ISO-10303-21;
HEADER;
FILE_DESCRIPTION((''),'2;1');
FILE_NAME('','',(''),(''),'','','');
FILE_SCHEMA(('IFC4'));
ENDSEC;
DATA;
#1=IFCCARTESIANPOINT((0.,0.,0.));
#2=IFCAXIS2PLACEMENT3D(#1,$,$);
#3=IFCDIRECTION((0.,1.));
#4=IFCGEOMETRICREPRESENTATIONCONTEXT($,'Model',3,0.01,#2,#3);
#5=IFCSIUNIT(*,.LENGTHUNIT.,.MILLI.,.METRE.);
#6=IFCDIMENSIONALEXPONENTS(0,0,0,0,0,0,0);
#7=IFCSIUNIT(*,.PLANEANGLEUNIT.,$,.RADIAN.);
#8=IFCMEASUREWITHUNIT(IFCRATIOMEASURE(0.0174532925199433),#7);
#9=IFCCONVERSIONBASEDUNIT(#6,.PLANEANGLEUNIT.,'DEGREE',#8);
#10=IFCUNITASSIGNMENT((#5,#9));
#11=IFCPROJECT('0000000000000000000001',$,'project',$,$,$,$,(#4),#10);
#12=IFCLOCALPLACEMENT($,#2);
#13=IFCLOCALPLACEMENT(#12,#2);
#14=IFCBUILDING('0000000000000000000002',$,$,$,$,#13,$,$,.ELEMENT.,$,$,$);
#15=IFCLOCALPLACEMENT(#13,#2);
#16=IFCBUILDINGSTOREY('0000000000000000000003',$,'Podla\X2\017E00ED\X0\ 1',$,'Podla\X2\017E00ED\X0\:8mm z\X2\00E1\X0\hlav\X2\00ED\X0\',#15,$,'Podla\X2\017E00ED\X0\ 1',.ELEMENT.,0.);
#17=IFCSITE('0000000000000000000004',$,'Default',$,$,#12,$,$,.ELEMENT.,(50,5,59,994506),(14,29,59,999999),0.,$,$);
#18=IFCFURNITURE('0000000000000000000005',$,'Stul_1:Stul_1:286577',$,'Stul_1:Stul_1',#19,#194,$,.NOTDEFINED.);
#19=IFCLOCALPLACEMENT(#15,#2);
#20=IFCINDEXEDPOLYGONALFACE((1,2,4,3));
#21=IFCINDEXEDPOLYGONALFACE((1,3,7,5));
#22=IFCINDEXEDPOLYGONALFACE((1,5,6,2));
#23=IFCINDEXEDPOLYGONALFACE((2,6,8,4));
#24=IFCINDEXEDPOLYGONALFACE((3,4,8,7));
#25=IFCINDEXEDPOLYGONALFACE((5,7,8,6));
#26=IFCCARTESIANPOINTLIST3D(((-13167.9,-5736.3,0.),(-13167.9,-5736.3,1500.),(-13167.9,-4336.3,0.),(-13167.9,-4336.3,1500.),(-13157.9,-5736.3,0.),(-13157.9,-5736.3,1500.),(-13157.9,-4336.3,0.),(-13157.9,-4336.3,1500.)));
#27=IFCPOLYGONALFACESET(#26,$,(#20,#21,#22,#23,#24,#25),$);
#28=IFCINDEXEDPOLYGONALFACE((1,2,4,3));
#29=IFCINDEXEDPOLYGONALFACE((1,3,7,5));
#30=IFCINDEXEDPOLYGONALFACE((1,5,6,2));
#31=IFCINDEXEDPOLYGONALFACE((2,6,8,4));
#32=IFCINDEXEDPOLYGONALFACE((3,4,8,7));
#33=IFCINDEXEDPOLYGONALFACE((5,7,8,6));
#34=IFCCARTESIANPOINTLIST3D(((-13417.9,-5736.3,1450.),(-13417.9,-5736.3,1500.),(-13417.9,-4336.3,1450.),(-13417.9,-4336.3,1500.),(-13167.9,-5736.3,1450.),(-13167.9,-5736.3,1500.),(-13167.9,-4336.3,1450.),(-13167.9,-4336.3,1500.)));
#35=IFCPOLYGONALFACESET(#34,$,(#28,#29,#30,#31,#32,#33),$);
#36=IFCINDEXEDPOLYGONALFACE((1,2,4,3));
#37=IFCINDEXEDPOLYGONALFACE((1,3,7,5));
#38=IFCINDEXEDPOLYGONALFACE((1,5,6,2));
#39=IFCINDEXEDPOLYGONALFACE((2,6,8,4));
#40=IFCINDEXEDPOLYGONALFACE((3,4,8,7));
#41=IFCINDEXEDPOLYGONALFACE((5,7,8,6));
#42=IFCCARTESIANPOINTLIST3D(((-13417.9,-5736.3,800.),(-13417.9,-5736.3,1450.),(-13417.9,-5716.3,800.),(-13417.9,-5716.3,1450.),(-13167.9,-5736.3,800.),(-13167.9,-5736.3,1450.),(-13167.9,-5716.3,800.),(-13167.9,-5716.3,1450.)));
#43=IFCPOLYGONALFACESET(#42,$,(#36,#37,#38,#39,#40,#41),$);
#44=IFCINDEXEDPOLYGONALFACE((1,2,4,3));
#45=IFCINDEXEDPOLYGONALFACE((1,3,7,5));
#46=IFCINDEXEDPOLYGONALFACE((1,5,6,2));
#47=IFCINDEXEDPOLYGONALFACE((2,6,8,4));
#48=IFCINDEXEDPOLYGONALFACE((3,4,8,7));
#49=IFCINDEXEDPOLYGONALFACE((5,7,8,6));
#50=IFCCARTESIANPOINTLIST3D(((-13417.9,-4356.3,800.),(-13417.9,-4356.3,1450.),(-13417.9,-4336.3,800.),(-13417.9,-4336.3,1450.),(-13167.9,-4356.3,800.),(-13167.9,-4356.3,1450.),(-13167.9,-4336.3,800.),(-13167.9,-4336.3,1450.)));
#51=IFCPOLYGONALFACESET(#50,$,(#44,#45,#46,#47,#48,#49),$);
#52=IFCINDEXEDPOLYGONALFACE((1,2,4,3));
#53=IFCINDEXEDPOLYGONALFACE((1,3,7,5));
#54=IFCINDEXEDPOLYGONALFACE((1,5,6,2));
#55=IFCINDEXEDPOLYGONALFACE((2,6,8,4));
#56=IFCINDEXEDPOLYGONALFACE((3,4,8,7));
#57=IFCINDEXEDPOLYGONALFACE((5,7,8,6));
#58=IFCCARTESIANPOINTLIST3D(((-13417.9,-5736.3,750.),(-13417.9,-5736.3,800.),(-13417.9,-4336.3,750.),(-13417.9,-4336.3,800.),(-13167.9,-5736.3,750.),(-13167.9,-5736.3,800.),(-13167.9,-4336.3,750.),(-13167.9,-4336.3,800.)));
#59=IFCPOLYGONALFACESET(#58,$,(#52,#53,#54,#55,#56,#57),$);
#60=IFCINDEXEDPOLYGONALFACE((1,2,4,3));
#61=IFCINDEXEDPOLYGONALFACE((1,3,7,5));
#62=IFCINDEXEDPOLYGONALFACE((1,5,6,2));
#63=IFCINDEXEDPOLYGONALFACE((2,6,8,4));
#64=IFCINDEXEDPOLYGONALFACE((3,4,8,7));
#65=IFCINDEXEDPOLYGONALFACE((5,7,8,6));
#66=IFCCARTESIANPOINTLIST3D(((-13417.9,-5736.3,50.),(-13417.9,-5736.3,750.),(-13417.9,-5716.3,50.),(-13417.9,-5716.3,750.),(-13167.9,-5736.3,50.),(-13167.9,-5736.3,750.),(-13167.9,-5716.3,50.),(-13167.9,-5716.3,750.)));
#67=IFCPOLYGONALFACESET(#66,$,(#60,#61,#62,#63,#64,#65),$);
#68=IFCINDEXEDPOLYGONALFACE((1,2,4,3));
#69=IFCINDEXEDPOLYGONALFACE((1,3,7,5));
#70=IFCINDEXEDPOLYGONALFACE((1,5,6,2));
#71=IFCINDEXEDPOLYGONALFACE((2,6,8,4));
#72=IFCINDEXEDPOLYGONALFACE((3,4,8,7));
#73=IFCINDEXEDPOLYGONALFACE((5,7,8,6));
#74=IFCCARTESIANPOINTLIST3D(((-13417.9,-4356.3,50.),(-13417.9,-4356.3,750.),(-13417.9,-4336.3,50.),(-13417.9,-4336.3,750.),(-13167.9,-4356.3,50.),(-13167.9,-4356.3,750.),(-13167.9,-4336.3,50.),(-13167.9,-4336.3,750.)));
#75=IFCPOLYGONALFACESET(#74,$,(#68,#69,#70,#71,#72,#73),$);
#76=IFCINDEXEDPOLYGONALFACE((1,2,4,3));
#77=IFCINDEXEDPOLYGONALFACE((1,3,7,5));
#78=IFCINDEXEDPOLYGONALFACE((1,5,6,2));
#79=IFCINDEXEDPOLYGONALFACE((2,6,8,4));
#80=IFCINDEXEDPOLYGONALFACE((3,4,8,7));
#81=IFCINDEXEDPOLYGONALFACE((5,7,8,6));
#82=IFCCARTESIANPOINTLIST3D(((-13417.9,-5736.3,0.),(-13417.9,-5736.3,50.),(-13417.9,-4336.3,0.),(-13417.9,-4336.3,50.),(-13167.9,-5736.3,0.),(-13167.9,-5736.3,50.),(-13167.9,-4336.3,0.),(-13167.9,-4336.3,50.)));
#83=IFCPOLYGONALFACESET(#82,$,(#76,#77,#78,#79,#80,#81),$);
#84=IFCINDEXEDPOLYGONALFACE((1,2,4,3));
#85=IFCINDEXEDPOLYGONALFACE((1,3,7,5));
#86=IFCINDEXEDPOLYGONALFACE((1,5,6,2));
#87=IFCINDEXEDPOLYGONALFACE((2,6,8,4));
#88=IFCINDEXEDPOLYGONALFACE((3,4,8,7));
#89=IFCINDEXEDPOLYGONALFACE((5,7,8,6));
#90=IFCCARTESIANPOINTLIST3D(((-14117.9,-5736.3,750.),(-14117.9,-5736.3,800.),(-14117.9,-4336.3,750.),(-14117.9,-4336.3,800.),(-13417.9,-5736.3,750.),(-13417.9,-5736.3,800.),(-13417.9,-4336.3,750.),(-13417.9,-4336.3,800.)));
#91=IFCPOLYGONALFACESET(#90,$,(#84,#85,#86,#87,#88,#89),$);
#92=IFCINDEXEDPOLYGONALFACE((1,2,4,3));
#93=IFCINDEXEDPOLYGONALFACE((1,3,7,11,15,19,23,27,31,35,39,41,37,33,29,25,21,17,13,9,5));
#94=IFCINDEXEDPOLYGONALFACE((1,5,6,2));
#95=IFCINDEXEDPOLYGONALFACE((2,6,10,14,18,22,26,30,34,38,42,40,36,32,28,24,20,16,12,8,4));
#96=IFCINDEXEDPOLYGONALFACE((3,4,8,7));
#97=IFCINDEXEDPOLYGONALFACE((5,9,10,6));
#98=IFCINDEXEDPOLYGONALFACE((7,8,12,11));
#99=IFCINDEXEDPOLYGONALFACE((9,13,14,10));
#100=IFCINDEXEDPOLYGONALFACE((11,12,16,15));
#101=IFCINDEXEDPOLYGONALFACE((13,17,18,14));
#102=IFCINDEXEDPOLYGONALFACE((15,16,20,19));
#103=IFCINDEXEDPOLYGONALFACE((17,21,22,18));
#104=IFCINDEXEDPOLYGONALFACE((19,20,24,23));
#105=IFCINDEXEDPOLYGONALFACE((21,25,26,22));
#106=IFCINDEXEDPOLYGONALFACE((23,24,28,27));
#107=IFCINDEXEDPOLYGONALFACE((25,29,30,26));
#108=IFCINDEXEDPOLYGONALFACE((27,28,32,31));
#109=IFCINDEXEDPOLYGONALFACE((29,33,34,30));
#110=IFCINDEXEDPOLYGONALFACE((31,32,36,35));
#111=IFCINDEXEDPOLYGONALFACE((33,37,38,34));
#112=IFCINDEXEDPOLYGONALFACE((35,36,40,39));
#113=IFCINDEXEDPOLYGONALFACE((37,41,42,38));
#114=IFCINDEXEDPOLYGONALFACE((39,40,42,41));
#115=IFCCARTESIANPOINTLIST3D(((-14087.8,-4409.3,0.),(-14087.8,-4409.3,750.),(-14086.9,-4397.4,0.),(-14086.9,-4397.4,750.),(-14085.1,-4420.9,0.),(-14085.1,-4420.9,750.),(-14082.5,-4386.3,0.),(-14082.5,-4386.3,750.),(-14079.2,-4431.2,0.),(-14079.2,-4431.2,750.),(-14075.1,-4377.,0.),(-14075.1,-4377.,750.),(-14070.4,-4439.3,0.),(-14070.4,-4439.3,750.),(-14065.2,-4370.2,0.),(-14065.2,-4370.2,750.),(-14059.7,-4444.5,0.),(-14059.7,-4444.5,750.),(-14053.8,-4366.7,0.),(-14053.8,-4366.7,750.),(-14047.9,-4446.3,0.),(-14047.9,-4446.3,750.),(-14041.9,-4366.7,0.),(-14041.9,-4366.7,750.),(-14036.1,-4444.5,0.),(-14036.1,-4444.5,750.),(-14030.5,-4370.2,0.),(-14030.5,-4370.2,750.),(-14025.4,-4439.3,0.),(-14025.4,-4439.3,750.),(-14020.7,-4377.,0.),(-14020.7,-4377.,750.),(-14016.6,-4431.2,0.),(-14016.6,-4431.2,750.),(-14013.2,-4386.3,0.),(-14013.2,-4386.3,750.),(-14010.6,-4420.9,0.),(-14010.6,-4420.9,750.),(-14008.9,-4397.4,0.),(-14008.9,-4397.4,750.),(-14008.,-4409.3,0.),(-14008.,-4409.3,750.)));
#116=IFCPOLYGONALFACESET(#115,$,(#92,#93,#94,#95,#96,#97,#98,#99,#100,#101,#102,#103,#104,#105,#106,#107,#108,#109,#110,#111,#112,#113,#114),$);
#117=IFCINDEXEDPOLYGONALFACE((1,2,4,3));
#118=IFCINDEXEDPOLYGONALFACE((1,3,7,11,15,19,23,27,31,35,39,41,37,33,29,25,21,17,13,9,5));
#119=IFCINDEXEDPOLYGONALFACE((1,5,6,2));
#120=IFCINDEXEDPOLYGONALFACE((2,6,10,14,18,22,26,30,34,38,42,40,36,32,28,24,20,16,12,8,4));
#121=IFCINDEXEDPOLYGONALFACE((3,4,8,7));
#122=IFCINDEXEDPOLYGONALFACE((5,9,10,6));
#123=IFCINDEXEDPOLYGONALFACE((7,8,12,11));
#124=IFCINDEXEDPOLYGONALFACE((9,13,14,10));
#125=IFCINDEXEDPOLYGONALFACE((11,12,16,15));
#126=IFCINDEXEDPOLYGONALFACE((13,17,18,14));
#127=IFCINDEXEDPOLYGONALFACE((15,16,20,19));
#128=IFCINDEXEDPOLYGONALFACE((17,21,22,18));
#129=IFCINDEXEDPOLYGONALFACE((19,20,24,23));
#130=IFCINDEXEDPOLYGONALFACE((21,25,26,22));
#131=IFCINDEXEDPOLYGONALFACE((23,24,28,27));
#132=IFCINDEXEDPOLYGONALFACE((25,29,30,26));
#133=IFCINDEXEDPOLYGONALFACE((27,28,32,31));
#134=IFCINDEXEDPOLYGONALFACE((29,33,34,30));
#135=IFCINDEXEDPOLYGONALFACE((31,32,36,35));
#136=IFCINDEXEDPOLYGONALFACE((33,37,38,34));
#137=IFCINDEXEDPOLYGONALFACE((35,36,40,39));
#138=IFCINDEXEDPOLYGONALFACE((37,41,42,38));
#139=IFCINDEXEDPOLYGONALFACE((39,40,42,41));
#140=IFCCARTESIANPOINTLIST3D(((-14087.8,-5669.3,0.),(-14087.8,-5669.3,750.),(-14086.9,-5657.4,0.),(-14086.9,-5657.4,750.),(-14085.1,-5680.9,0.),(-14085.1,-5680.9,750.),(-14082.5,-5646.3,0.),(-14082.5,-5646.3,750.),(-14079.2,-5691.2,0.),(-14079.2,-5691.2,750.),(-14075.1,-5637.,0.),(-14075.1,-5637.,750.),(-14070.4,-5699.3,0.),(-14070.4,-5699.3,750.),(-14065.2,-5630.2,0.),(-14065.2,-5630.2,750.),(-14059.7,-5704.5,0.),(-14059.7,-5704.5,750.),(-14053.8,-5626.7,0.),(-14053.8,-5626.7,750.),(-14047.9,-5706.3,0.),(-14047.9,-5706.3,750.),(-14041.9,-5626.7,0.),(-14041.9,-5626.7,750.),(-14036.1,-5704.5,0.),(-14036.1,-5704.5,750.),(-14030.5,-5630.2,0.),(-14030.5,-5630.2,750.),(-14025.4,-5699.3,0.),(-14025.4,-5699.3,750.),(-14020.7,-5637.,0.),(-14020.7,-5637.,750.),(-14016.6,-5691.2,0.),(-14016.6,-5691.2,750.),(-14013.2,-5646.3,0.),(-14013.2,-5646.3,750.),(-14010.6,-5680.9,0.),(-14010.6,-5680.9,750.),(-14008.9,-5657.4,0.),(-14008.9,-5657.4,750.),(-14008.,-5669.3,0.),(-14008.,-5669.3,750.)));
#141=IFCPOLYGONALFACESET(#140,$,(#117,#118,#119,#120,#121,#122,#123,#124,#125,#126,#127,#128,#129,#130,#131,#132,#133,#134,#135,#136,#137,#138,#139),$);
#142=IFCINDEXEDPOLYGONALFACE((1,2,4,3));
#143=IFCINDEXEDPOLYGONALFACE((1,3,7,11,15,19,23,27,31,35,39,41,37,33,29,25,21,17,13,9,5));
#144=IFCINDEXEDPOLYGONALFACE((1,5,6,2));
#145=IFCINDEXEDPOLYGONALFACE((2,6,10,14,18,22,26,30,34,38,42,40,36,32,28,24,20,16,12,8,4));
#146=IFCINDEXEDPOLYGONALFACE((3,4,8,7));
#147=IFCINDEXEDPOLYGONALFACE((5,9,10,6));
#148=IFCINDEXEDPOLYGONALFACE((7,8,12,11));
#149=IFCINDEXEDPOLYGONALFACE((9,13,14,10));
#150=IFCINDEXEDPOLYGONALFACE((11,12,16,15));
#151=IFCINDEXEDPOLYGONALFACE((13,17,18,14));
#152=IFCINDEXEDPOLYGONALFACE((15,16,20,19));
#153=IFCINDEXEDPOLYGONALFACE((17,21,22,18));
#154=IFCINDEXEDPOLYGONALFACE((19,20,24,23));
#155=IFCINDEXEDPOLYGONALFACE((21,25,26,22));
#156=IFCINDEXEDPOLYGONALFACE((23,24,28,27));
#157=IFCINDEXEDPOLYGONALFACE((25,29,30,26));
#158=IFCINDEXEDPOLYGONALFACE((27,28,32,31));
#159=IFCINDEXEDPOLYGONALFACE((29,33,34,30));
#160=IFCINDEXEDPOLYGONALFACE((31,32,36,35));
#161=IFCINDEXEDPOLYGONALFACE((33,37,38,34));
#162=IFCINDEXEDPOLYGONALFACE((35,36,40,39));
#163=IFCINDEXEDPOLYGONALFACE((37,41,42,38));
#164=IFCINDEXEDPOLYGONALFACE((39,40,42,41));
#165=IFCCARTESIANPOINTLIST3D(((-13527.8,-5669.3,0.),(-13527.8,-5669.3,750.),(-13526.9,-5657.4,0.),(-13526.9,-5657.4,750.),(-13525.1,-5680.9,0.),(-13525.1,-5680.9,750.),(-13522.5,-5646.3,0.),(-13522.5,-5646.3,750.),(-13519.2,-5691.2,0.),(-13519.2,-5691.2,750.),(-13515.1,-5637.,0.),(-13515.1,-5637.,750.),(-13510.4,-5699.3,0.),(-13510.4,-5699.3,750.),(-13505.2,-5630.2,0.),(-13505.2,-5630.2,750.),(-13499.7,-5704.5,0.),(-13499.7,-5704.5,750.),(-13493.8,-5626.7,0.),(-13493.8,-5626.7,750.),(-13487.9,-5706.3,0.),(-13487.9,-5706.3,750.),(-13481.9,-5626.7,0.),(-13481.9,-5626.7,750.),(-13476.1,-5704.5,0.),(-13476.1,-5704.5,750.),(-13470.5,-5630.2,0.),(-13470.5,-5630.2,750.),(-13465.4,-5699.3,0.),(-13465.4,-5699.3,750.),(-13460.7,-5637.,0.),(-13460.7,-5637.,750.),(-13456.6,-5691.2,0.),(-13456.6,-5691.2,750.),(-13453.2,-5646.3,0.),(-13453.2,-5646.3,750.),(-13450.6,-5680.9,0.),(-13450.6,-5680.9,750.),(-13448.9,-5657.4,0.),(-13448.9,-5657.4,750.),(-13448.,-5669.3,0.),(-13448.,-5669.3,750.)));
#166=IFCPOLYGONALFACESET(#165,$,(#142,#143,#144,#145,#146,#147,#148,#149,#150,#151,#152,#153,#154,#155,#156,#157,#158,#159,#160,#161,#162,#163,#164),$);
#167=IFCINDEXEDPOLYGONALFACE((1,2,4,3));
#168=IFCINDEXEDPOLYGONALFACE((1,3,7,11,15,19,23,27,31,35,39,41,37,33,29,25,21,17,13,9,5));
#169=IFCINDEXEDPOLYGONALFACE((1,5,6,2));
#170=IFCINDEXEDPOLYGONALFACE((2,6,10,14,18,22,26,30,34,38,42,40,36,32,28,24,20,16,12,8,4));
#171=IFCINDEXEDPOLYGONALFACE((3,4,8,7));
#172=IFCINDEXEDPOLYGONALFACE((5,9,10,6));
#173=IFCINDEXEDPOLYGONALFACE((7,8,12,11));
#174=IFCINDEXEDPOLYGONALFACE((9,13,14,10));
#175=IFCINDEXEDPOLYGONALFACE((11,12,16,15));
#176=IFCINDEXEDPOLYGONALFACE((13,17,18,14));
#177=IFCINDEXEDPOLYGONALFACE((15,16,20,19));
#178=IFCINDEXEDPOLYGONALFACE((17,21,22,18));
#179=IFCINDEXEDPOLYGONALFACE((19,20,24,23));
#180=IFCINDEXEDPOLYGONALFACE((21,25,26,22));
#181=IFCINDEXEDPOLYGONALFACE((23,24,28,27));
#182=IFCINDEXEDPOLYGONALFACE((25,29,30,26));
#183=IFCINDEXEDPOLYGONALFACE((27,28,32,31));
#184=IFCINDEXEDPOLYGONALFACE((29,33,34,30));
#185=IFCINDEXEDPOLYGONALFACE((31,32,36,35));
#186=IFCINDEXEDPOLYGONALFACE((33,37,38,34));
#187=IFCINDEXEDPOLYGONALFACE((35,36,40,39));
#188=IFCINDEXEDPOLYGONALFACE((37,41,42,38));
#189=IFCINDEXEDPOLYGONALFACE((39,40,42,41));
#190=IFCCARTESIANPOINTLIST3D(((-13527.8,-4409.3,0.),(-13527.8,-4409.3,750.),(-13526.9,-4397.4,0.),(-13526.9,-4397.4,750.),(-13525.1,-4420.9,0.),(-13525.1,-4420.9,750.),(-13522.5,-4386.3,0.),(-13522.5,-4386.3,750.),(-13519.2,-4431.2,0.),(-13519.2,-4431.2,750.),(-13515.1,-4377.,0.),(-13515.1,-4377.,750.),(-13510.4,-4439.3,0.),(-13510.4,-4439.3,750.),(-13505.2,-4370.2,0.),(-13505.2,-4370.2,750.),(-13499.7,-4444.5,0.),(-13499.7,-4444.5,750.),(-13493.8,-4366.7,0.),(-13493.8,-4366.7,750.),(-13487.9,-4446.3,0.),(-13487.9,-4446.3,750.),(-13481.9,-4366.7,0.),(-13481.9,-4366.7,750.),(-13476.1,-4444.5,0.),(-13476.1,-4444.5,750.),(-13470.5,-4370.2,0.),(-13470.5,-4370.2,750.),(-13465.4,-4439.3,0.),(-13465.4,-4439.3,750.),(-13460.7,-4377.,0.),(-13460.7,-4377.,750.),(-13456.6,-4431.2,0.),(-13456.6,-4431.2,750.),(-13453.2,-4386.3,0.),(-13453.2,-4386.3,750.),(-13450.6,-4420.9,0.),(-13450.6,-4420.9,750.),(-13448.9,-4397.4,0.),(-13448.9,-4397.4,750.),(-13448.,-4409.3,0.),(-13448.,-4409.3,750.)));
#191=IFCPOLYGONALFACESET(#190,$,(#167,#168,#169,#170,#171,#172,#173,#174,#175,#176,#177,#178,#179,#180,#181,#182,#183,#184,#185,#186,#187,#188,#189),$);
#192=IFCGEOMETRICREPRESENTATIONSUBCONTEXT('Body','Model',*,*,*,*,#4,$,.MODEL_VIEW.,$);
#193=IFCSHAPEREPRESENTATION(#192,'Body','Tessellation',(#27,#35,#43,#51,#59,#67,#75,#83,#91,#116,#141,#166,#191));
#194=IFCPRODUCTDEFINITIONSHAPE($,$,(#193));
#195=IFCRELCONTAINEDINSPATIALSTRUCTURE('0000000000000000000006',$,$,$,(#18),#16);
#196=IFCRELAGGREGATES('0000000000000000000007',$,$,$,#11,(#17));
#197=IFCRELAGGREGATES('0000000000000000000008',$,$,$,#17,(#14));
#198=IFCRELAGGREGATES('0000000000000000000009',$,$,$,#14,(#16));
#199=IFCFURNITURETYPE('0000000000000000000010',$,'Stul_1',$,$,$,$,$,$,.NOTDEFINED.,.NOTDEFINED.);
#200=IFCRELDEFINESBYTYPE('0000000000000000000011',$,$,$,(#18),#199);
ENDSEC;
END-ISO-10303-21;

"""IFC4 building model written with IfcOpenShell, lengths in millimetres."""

from ifc_helpers import new_model, entity, si_unit, converted_unit, direction, frame, frame_2d, origin, origin_2d_with_axis, place, context, subcontext, project, spatial, rectangle, circle, extrude, source, transform, mapped, type_object, type_shapes, element, save


model = new_model("IFC4")

# Units and contexts
model_context = context("Model", 3, precision=0.01, world=origin(), true_north=direction((0.0, 1.0)))
body_context = subcontext(model_context, "Body", "Model", "MODEL_VIEW")
ifc_project = project(units=[si_unit("LENGTHUNIT", "METRE", prefix="MILLI"), converted_unit("PLANEANGLEUNIT", "DEGREE", entity("IfcRatioMeasure", 0.0174532925199433), si_unit("PLANEANGLEUNIT", "RADIAN"), dimensions=[0, 0, 0, 0, 0, 0, 0])], contexts=[model_context])

# Site, building, storey
site_placement = place(None, origin())
site = spatial("IfcSite", under=ifc_project, at=site_placement, Name="Default", CompositionType="ELEMENT", RefLatitude=(50, 5, 59, 994506), RefLongitude=(14, 29, 59, 999999), RefElevation=0.0)
building_placement = place(site_placement, origin())
building = spatial("IfcBuilding", under=site, at=building_placement, CompositionType="ELEMENT")
storey_placement = place(building_placement, origin())
storey = spatial("IfcBuildingStorey", under=building, at=storey_placement, Name="Podlaží 1", ObjectType="Podlaží:8mm záhlaví", LongName="Podlaží 1", CompositionType="ELEMENT", Elevation=0.0)

# Furniture
furniture_type = type_object("IfcFurnitureType", Name="Stul_1", AssemblyPlace="NOTDEFINED", PredefinedType="NOTDEFINED")
shared_shape_1 = source(origin(), body_context, "Body", "SweptSolid", [
    extrude(rectangle(XDim=1400.0, YDim=10.0, at=origin_2d_with_axis()), frame((0.0, 605.0, 0.0), z_axis=(0.0, 0.0, 1.0), x_axis=(-1.0, 0.0, 0.0)), (0.0, 0.0, 1.0), 1500.0),
    extrude(rectangle(XDim=1400.0, YDim=250.0, at=frame_2d((0.0, 0.0), x_axis=(1.0, 0.0))), frame((0.0, 475.0, 1450.0), z_axis=(0.0, 0.0, 1.0), x_axis=(-1.0, 0.0, 0.0)), (0.0, 0.0, 1.0), 50.0),
    extrude(rectangle(XDim=20.0, YDim=250.0, at=origin_2d_with_axis()), frame((690.0, 475.0, 800.0), z_axis=(0.0, 0.0, 1.0), x_axis=(-1.0, 0.0, 0.0)), (0.0, 0.0, 1.0), 650.0),
    extrude(rectangle(XDim=20.0, YDim=250.0, at=frame_2d((0.0, 0.0), x_axis=(1.0, 0.0))), frame((-690.0, 475.0, 800.0), z_axis=(0.0, 0.0, 1.0), x_axis=(-1.0, 0.0, 0.0)), (0.0, 0.0, 1.0), 650.0),
    extrude(rectangle(XDim=1400.0, YDim=250.0, at=origin_2d_with_axis()), frame((0.0, 475.0, 750.0), z_axis=(0.0, 0.0, 1.0), x_axis=(-1.0, 0.0, 0.0)), (0.0, 0.0, 1.0), 50.0),
    extrude(rectangle(XDim=20.0, YDim=250.0, at=origin_2d_with_axis()), frame((690.0, 475.0, 50.0), z_axis=(0.0, 0.0, 1.0), x_axis=(-1.0, 0.0, 0.0)), (0.0, 0.0, 1.0), 700.0),
    extrude(rectangle(XDim=20.0, YDim=250.0, at=frame_2d((0.0, 0.0), x_axis=(1.0, 0.0))), frame((-690.0, 475.0, 50.0), z_axis=(0.0, 0.0, 1.0), x_axis=(-1.0, 0.0, 0.0)), (0.0, 0.0, 1.0), 700.0),
    extrude(rectangle(XDim=1400.0, YDim=250.0, at=origin_2d_with_axis()), frame((0.0, 475.0, 0.0), z_axis=(0.0, 0.0, 1.0), x_axis=(-1.0, 0.0, 0.0)), (0.0, 0.0, 1.0), 50.0),
    extrude(rectangle(XDim=1400.0, YDim=700.0, at=origin_2d_with_axis()), frame((0.0, 0.0, 750.0), z_axis=(0.0, 0.0, 1.0), x_axis=(-1.0, 0.0, 0.0)), (0.0, 0.0, 1.0), 50.0),
    extrude(circle(Radius=40.0, at=frame_2d((0.0, 0.0), x_axis=(1.0, 0.0))), frame((-630.0, -280.0, 0.0)), (0.0, 0.0, 1.0), 750.0),
    extrude(circle(Radius=40.0, at=frame_2d((0.0, 0.0), x_axis=(1.0, 0.0))), frame((630.0, -280.0, 0.0)), (0.0, 0.0, 1.0), 750.0),
    extrude(circle(Radius=40.0, at=frame_2d((0.0, 0.0), x_axis=(1.0, 0.0))), frame((630.0, 280.0, 0.0)), (0.0, 0.0, 1.0), 750.0),
    extrude(circle(Radius=40.0, at=frame_2d((0.0, 0.0), x_axis=(1.0, 0.0))), frame((-630.0, 280.0, 0.0)), (0.0, 0.0, 1.0), 750.0),
])
type_shapes(furniture_type, [shared_shape_1])
for number, where, z_axis, x_axis, name in (
    (1, (-13767.9, -5036.3, 0.0), (0.0, 0.0, 1.0), (0.0, -1.0, 0.0), "Stul_1:Stul_1:286577"),
):
    element("IfcFurniture", number, at=place(storey_placement, frame(where, z_axis=z_axis, x_axis=x_axis)), inside=storey, type_object=furniture_type, Name=name, ObjectType="Stul_1:Stul_1", PredefinedType="NOTDEFINED", context=body_context, shape_type="MappedRepresentation", body=[
        mapped(shared_shape_1, transform((0.0, 0.0, 0.0), scale=1.0)),
    ])

save(model, "model.ifc")
